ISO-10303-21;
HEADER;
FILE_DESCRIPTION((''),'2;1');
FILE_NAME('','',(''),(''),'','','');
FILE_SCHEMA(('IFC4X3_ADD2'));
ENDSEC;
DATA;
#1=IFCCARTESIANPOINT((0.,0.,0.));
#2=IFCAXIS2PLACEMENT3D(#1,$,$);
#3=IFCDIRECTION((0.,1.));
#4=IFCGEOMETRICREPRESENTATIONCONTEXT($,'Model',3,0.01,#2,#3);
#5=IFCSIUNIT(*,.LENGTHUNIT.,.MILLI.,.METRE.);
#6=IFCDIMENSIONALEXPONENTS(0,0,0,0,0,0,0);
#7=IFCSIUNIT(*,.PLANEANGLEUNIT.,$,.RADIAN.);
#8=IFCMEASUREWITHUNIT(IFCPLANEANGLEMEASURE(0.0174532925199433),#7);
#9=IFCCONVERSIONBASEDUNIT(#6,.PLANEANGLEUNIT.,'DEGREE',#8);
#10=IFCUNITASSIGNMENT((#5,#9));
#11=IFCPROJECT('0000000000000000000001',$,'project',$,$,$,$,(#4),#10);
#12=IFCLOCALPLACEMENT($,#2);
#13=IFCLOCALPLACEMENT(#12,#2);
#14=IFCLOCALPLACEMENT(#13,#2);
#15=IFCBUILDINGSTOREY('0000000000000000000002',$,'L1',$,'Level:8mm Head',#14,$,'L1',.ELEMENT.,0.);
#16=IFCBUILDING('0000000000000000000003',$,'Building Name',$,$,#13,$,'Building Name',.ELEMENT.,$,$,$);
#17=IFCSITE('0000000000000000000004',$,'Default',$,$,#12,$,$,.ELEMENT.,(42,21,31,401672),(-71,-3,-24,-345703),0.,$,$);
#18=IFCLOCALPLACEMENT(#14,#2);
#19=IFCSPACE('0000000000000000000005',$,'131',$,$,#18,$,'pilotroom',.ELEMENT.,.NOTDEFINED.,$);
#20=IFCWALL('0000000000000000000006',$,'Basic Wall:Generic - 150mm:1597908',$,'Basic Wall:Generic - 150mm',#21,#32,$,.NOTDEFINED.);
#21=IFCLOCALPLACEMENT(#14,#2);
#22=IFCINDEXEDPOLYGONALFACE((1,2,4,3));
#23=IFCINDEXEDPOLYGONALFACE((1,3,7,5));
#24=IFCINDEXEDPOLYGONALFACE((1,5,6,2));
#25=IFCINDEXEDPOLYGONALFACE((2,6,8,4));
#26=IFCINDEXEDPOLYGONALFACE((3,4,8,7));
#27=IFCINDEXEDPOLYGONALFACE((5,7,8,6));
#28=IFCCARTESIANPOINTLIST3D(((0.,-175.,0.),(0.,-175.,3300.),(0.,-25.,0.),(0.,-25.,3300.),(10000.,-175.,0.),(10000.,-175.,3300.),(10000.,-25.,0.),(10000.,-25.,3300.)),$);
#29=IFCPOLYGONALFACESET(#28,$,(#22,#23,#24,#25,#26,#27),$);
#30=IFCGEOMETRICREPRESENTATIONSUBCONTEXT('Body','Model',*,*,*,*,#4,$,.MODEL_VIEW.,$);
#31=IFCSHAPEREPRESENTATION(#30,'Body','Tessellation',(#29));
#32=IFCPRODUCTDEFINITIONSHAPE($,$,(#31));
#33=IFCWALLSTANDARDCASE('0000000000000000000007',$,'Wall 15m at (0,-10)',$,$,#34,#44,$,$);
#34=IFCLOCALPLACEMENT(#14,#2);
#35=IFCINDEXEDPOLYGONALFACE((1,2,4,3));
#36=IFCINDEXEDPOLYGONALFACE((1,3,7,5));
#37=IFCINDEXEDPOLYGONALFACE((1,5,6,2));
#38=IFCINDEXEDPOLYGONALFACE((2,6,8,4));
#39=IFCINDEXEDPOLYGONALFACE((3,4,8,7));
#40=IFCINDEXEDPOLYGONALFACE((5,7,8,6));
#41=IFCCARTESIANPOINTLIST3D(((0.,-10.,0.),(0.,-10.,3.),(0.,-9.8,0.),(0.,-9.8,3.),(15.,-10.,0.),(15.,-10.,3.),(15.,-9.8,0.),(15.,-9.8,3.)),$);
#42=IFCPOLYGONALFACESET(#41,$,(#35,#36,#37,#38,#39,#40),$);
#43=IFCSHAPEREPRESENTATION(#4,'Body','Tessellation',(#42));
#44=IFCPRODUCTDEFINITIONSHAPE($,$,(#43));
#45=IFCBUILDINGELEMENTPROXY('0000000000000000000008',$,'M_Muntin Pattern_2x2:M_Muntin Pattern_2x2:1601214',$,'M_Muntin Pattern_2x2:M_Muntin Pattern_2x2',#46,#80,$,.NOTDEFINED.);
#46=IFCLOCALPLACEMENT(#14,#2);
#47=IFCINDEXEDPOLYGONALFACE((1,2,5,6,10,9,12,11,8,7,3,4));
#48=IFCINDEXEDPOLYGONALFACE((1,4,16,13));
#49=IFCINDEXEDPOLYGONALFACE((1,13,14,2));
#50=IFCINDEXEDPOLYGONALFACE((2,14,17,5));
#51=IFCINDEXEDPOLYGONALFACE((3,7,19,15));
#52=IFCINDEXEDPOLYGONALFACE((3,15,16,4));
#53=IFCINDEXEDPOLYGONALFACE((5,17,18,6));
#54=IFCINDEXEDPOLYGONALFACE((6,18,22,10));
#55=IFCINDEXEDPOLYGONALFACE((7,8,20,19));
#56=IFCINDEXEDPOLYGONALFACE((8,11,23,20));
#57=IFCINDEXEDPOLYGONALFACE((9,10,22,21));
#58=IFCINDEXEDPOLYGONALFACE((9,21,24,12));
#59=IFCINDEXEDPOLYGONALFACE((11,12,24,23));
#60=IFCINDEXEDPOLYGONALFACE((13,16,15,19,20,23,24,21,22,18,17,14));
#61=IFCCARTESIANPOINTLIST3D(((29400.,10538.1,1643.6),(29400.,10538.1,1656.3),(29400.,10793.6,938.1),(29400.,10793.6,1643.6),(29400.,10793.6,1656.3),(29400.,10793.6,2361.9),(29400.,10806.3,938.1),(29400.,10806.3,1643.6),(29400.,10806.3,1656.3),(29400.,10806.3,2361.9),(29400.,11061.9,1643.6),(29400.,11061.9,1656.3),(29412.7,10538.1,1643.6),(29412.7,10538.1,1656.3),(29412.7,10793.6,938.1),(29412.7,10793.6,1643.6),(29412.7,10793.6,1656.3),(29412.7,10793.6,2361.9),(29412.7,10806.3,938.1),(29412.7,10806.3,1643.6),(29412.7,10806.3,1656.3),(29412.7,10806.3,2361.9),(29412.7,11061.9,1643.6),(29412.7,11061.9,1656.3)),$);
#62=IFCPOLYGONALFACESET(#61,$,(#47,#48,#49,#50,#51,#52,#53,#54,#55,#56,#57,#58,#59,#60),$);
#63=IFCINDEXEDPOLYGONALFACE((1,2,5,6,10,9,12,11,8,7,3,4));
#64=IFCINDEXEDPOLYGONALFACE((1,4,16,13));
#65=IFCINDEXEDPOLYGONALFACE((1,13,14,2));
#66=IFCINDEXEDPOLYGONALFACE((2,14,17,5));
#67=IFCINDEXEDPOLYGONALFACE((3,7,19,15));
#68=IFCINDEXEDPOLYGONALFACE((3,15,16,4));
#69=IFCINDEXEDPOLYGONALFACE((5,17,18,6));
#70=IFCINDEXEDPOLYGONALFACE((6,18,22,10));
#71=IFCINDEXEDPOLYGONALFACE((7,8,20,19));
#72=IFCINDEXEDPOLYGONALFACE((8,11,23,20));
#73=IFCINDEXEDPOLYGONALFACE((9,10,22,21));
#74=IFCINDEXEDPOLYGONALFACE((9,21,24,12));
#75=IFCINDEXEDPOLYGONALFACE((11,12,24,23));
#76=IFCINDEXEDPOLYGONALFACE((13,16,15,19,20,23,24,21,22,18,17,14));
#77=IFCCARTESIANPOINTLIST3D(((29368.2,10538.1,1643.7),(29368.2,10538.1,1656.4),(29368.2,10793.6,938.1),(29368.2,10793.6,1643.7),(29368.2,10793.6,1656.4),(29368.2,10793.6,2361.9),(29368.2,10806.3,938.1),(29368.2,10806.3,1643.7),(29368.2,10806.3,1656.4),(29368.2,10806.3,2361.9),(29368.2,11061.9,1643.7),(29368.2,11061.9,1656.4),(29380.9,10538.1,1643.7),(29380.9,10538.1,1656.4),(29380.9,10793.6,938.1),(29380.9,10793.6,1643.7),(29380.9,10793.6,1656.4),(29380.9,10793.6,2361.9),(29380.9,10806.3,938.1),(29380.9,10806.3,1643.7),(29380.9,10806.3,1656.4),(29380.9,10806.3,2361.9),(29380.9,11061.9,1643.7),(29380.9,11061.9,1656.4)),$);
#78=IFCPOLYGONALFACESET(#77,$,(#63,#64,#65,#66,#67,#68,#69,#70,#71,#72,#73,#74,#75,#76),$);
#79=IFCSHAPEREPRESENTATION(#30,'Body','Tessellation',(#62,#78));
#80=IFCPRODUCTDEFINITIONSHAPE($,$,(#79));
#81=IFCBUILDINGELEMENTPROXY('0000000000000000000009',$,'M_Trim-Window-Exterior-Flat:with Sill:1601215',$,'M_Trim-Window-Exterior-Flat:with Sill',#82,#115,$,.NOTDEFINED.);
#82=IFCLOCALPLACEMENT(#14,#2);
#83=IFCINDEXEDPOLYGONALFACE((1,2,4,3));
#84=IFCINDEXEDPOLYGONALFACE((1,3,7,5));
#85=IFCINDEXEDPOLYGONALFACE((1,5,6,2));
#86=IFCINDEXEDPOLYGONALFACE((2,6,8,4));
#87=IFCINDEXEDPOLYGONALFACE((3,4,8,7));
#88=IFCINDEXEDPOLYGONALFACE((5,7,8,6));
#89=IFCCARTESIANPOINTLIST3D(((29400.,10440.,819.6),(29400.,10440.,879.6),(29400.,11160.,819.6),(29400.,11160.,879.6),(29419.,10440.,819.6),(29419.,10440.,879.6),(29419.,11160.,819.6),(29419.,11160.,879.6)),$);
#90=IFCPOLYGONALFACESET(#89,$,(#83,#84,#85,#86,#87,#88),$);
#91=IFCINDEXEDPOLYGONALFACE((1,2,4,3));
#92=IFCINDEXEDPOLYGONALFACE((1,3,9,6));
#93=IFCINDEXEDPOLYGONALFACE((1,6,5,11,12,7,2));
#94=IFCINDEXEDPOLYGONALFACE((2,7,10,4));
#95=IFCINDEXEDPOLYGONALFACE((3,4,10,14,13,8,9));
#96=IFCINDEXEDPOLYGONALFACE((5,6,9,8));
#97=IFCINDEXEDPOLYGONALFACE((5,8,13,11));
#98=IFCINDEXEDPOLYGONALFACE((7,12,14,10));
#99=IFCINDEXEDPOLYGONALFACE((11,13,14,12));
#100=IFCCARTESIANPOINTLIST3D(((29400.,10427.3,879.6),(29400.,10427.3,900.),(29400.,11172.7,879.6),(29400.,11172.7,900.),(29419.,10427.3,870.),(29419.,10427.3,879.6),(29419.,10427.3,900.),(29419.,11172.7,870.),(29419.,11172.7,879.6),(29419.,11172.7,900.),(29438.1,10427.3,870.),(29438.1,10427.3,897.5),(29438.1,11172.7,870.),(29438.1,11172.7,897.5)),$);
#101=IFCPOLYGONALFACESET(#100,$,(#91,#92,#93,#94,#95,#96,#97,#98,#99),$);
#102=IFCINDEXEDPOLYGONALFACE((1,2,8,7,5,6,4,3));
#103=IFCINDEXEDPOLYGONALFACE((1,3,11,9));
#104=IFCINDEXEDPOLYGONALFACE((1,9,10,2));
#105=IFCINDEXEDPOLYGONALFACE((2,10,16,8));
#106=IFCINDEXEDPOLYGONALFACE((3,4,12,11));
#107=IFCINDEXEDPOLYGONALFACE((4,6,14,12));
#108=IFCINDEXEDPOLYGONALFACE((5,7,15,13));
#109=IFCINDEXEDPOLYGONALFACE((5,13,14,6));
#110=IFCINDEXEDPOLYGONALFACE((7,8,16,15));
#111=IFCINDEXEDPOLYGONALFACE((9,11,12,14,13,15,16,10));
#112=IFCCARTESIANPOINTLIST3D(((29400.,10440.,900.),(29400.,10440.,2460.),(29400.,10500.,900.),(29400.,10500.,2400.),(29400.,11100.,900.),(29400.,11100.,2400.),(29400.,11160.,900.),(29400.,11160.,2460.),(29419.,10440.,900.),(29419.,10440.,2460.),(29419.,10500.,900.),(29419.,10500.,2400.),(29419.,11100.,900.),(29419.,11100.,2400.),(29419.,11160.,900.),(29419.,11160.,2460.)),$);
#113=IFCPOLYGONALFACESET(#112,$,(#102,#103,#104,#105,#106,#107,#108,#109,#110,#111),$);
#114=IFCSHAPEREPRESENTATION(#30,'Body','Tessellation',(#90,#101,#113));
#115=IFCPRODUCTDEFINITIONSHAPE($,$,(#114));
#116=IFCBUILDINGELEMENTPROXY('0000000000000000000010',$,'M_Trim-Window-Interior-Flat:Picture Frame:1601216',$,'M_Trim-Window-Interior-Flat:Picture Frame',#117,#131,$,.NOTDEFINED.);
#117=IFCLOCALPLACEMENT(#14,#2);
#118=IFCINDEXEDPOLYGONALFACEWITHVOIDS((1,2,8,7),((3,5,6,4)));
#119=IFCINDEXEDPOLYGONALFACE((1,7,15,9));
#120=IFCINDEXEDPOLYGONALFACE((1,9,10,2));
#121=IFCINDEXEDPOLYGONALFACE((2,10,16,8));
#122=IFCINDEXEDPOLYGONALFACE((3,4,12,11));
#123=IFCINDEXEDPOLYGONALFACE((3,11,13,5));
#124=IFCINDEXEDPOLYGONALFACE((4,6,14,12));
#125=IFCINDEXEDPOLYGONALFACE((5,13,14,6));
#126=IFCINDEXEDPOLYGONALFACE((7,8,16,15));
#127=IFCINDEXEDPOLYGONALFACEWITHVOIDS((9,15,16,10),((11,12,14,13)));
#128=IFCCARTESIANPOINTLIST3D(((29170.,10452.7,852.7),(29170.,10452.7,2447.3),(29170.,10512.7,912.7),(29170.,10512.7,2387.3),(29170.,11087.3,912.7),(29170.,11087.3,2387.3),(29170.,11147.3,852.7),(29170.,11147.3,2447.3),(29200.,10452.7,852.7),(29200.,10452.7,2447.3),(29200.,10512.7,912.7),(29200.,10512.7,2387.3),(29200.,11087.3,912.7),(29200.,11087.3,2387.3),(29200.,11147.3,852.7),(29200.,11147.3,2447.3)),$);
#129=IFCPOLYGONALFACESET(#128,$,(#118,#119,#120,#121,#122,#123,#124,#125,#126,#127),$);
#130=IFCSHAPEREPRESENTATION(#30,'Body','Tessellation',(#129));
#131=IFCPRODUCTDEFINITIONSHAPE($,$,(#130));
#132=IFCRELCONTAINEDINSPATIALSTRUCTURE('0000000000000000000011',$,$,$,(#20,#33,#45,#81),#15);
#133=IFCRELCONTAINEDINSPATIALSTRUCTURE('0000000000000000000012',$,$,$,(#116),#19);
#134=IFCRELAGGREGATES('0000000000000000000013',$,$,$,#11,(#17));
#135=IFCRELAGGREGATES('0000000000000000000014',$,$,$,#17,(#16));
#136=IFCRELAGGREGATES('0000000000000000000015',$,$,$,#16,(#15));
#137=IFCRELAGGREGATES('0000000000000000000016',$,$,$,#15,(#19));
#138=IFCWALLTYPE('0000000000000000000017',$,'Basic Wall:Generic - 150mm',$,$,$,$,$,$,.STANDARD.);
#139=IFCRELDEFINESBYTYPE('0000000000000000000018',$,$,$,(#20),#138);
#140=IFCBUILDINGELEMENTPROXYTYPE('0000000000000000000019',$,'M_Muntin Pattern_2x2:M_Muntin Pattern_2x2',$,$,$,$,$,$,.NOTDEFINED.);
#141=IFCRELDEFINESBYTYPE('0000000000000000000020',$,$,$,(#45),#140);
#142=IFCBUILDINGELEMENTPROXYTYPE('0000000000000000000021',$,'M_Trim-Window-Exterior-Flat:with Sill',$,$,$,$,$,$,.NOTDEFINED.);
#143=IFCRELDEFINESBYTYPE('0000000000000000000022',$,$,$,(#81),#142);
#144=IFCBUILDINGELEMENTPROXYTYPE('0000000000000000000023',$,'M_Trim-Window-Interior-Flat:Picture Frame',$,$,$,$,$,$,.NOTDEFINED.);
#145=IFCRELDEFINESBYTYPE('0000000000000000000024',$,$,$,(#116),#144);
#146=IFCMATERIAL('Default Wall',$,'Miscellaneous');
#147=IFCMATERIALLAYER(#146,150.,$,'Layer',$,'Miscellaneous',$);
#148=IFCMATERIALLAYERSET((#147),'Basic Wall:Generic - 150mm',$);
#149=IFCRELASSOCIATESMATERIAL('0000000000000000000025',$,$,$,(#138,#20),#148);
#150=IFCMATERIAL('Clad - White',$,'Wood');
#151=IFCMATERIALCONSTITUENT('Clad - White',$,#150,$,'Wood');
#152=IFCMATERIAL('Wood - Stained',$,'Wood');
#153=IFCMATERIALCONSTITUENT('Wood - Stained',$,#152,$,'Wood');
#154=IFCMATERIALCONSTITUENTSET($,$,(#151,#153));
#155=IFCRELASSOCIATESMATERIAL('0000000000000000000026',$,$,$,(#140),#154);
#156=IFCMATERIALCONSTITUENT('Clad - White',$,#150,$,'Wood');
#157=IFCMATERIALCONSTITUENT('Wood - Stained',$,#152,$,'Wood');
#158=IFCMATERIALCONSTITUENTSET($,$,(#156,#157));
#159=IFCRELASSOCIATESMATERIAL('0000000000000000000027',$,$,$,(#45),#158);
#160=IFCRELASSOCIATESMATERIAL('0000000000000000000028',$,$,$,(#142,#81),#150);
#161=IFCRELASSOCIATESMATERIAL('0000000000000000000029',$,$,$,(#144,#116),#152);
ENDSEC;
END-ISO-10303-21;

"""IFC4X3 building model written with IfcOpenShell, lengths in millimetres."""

from ifc_helpers import new_model, entity, si_unit, converted_unit, direction, frame, frame_2d, origin, place, context, subcontext, project, spatial, polyline, rectangle, outline, extrude, source, transform, mapped, material, layer, layer_set, constituent, constituent_set, type_object, type_shapes, element, save


model = new_model("IFC4X3")

# Units and contexts
model_context = context("Model", 3, precision=0.01, world=origin(), true_north=direction((0.0, 1.0)))
body_context = subcontext(model_context, "Body", "Model", "MODEL_VIEW")
ifc_project = project(units=[si_unit("LENGTHUNIT", "METRE", prefix="MILLI"), converted_unit("PLANEANGLEUNIT", "DEGREE", entity("IfcPlaneAngleMeasure", 0.0174532925199433), si_unit("PLANEANGLEUNIT", "RADIAN"), dimensions=[0, 0, 0, 0, 0, 0, 0])], contexts=[model_context])

# Site, building, storey
site_placement = place(None, origin())
site = spatial("IfcSite", under=ifc_project, at=site_placement, Name="Default", CompositionType="ELEMENT", RefLatitude=(42, 21, 31, 401672), RefLongitude=(-71, -3, -24, -345703), RefElevation=0.0)
building_placement = place(site_placement, origin())
building = spatial("IfcBuilding", under=site, at=building_placement, Name="Building Name", LongName="Building Name", CompositionType="ELEMENT")
storey_placement = place(building_placement, origin())
storey = spatial("IfcBuildingStorey", under=building, at=storey_placement, Name="L1", ObjectType="Level:8mm Head", LongName="L1", CompositionType="ELEMENT", Elevation=0.0)

# Shared definitions
ifc_material_1 = material(Name="Default Wall", Category="Miscellaneous")

# Walls
ifc_layer_1 = layer(ifc_material_1, 150.0, Name="Layer", Category="Miscellaneous")
ifc_layer_set_1 = layer_set([ifc_layer_1], Name="Basic Wall:Generic - 150mm")
wall_type_1 = type_object("IfcWallType", Name="Basic Wall:Generic - 150mm", PredefinedType="STANDARD", material=ifc_layer_set_1)
wall_1_placement = place(storey_placement, frame((0.0, -100.0, 0.0)))
element("IfcWall", 1, at=wall_1_placement, inside=storey, type_object=wall_type_1, material=ifc_layer_set_1, Name="Basic Wall:Generic - 150mm:1597908", ObjectType="Basic Wall:Generic - 150mm", PredefinedType="NOTDEFINED", context=body_context, shape_type="SweptSolid", body=[
    extrude(rectangle(XDim=10000.0, YDim=150.0, at=frame_2d((5000.0, 0.0), x_axis=(-1.0, 0.0))), origin(), (0.0, 0.0, 1.0), 3300.0),
])
wall_2_placement = place(storey_placement, frame((0.0, -10.0, 0.0), x_axis=(1.0, 0.0, 0.0)))
element("IfcWallStandardCase", 2, at=wall_2_placement, inside=storey, Name="Wall 15m at (0,-10)", context=model_context, shape_type="SweptSolid", body=[
    extrude(outline(polyline([(0.0, 0.0), (15.0, 0.0), (15.0, 0.2), (0.0, 0.2), (0.0, 0.0)])), origin(), (0.0, 0.0, 1.0), 3.0),
])

# Building element proxies
ifc_material_2 = material(Name="Clad - White", Category="Wood")
ifc_constituent_1 = constituent(ifc_material_2, Name="Clad - White", Category="Wood")
ifc_material_3 = material(Name="Wood - Stained", Category="Wood")
ifc_constituent_2 = constituent(ifc_material_3, Name="Wood - Stained", Category="Wood")
ifc_constituent_set_1 = constituent_set(constituents=[ifc_constituent_1, ifc_constituent_2])
ifc_constituent_3 = constituent(ifc_material_2, Name="Clad - White", Category="Wood")
ifc_constituent_4 = constituent(ifc_material_3, Name="Wood - Stained", Category="Wood")
ifc_constituent_set_2 = constituent_set(constituents=[ifc_constituent_3, ifc_constituent_4])
building_element_proxy_type_1 = type_object("IfcBuildingElementProxyType", Name="M_Muntin Pattern_2x2:M_Muntin Pattern_2x2", PredefinedType="NOTDEFINED", material=ifc_constituent_set_2)
shared_shape_1 = source(origin(), body_context, "Body", "SweptSolid", [
    extrude(outline(polyline([(6.4, -6.4), (711.9, -6.4), (711.9, 6.3), (6.4, 6.3), (6.4, 261.9), (-6.3, 261.9), (-6.3, 6.3), (-711.9, 6.3), (-711.9, -6.4), (-6.3, -6.4), (-6.3, -261.9), (6.4, -261.9), (6.4, -6.4)])), frame((0.0, -22.2, 711.9), z_axis=(0.0, 1.0, 0.0), x_axis=(0.0, 0.0, 1.0)), (0.0, 0.0, 1.0), 12.7),
    extrude(outline(polyline([(6.4, -6.4), (711.9, -6.4), (711.9, 6.3), (6.4, 6.3), (6.4, 261.9), (-6.3, 261.9), (-6.3, 6.3), (-711.9, 6.3), (-711.9, -6.4), (-6.3, -6.4), (-6.3, -261.9), (6.4, -261.9), (6.4, -6.4)])), frame((0.0, 9.5, 711.9), z_axis=(0.0, 1.0, 0.0), x_axis=(0.0, 0.0, 1.0)), (0.0, 0.0, 1.0), 12.7),
])
type_shapes(building_element_proxy_type_1, [shared_shape_1])
proxy_1_placement = place(storey_placement, frame((29390.5, 10800.0, 938.1), z_axis=(0.0, 0.0, 1.0), x_axis=(0.0, 1.0, 0.0)))
element("IfcBuildingElementProxy", 3, at=proxy_1_placement, inside=storey, type_object=building_element_proxy_type_1, material=ifc_constituent_set_1, Name="M_Muntin Pattern_2x2:M_Muntin Pattern_2x2:1601214", ObjectType="M_Muntin Pattern_2x2:M_Muntin Pattern_2x2", PredefinedType="NOTDEFINED", context=body_context, shape_type="MappedRepresentation", body=[
    mapped(shared_shape_1, transform((0.0, 0.0, 0.0), scale=1.0)),
])
building_element_proxy_type_2 = type_object("IfcBuildingElementProxyType", Name="M_Trim-Window-Exterior-Flat:with Sill", PredefinedType="NOTDEFINED", material=ifc_material_2)
shared_shape_2 = source(origin(), body_context, "Body", "SweptSolid", [
    extrude(rectangle(XDim=720.0, YDim=60.0, at=frame_2d((0.0, 0.0), x_axis=(1.0, 0.0))), frame((0.0, -1550.4, 0.0), z_axis=(0.0, 0.0, 1.0), x_axis=(-1.0, 0.0, 0.0)), (0.0, 0.0, 1.0), 19.1),
    extrude(outline(polyline([(-19.0, -15.2), (0.0, -15.2), (0.0, -5.7), (19.0, -5.7), (19.0, 14.8), (0.0, 14.8), (-19.0, 12.3), (-19.0, -15.2)])), frame((-372.7, -1514.8, 19.0), z_axis=(1.0, 0.0, 0.0), x_axis=(0.0, 0.0, -1.0)), (0.0, 0.0, 1.0), 745.4),
    extrude(outline(polyline([(-795.0, -360.0), (765.0, -360.0), (765.0, -300.0), (-735.0, -300.0), (-735.0, 300.0), (765.0, 300.0), (765.0, 360.0), (-795.0, 360.0), (-795.0, -360.0)])), frame((0.0, -735.0, 0.0), z_axis=(0.0, 0.0, 1.0), x_axis=(0.0, -1.0, 0.0)), (0.0, 0.0, 1.0), 19.1),
])
type_shapes(building_element_proxy_type_2, [shared_shape_2])
proxy_2_placement = place(storey_placement, frame((29400.0, 10800.0, 2400.0), z_axis=(1.0, 0.0, 0.0), x_axis=(0.0, 1.0, 0.0)))
element("IfcBuildingElementProxy", 4, at=proxy_2_placement, inside=storey, type_object=building_element_proxy_type_2, material=ifc_material_2, Name="M_Trim-Window-Exterior-Flat:with Sill:1601215", ObjectType="M_Trim-Window-Exterior-Flat:with Sill", PredefinedType="NOTDEFINED", context=body_context, shape_type="MappedRepresentation", body=[
    mapped(shared_shape_2, transform((0.0, 0.0, 0.0), scale=1.0)),
])

# Shared definitions
space_placement = place(storey_placement, origin())
space = spatial("IfcSpace", under=storey, at=space_placement, Name="131", LongName="pilotroom", CompositionType="ELEMENT", PredefinedType="NOTDEFINED")

# Building element proxy
building_element_proxy_type_3 = type_object("IfcBuildingElementProxyType", Name="M_Trim-Window-Interior-Flat:Picture Frame", PredefinedType="NOTDEFINED", material=ifc_material_3)
shared_shape_3 = source(origin(), body_context, "Body", "SweptSolid", [
    extrude(outline(polyline([(-347.3, -797.3), (347.3, -797.3), (347.3, 797.3), (-347.3, 797.3), (-347.3, -797.3)]), holes=[polyline([(-287.3, -737.3), (-287.3, 737.3), (287.3, 737.3), (287.3, -737.3), (-287.3, -737.3)])]), frame((0.0, -750.0, 0.0), z_axis=(0.0, 0.0, 1.0), x_axis=(-1.0, 0.0, 0.0)), (0.0, 0.0, 1.0), 30.0),
])
type_shapes(building_element_proxy_type_3, [shared_shape_3])
proxy_3_placement = place(space_placement, frame((29200.0, 10800.0, 2400.0), z_axis=(-1.0, 0.0, 0.0), x_axis=(0.0, -1.0, 0.0)))
element("IfcBuildingElementProxy", 5, at=proxy_3_placement, inside=space, type_object=building_element_proxy_type_3, material=ifc_material_3, Name="M_Trim-Window-Interior-Flat:Picture Frame:1601216", ObjectType="M_Trim-Window-Interior-Flat:Picture Frame", PredefinedType="NOTDEFINED", context=body_context, shape_type="MappedRepresentation", body=[
    mapped(shared_shape_3, transform((0.0, 0.0, 0.0), scale=1.0)),
])

save(model, "model.ifc")
